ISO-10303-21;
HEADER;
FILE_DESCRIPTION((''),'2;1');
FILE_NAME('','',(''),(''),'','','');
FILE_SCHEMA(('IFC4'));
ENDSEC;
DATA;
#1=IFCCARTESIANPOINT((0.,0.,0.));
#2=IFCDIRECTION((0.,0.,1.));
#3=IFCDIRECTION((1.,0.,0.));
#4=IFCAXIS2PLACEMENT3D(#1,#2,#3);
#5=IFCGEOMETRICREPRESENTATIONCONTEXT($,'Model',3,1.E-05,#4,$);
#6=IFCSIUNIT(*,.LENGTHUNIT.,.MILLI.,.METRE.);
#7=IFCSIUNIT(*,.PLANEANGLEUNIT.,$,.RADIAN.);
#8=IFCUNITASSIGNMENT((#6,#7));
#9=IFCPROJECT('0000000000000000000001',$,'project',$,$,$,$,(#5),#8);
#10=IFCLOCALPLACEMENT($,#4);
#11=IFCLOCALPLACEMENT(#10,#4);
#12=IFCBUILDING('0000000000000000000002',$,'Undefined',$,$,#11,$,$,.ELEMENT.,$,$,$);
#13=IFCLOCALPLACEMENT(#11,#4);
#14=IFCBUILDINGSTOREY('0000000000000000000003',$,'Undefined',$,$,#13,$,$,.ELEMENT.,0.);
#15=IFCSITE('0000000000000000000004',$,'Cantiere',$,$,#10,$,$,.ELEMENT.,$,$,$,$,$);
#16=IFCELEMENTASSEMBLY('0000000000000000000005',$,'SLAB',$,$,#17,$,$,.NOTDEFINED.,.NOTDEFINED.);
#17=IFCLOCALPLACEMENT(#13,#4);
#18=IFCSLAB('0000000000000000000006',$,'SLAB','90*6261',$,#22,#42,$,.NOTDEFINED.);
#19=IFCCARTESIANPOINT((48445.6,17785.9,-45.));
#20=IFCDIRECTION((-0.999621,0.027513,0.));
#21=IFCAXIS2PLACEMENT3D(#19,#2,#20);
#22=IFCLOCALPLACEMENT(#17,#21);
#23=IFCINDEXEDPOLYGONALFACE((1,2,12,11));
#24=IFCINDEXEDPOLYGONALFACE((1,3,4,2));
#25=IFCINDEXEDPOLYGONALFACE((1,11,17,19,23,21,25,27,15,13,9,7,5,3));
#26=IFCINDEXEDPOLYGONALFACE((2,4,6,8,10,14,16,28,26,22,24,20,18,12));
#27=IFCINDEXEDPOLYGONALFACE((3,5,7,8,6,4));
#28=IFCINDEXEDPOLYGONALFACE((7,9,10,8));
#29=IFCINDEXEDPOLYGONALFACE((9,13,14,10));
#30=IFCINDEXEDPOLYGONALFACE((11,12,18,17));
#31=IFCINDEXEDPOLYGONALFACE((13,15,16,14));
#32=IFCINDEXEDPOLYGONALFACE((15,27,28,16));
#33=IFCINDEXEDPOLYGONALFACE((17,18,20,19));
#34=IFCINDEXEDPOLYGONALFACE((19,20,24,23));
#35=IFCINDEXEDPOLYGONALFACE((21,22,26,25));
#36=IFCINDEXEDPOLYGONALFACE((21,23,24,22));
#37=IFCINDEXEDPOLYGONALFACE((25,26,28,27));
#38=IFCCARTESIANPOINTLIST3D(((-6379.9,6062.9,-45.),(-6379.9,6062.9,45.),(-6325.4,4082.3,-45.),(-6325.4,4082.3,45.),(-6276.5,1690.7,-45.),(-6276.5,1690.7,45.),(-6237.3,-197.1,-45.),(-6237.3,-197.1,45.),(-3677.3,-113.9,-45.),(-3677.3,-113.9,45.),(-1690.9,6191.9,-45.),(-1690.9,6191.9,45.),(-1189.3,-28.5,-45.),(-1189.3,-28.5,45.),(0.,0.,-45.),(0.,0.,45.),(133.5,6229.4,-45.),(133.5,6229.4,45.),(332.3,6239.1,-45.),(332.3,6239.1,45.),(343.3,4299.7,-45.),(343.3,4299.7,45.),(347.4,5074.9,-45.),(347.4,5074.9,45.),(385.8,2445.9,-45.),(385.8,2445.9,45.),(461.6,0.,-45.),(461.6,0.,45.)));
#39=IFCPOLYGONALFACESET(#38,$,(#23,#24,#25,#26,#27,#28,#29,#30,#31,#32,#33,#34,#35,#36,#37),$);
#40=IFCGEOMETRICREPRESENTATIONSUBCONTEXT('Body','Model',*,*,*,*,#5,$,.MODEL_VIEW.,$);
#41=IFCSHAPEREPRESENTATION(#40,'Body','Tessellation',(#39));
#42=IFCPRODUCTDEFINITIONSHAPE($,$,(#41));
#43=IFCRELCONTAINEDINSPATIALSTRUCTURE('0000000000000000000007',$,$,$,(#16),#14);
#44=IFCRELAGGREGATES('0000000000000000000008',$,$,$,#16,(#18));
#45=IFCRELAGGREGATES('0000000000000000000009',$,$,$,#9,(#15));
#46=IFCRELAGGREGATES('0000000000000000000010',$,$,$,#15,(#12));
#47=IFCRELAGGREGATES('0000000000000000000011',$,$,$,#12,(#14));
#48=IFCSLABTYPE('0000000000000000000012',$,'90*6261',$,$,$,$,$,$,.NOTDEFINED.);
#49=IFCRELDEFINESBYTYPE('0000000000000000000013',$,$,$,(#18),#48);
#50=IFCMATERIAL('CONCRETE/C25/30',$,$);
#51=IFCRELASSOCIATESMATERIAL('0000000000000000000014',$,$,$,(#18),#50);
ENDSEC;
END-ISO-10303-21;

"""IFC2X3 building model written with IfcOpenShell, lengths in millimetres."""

from ifc_helpers import new_model, si_unit, frame, origin_with_axes, place, context, subcontext, project, spatial, polyline, outline, extrude, material, type_object, element, aggregate, save


model = new_model("IFC2X3")

# Units and contexts
model_context = context("Model", 3, precision=1e-05, world=origin_with_axes())
body_context = subcontext(model_context, "Body", "Model", "MODEL_VIEW")
ifc_project = project(units=[si_unit("LENGTHUNIT", "METRE", prefix="MILLI"), si_unit("PLANEANGLEUNIT", "RADIAN")], contexts=[model_context])

# Site, building, storey
site_placement = place(None, origin_with_axes())
site = spatial("IfcSite", under=ifc_project, at=site_placement, Name="Cantiere", CompositionType="ELEMENT")
building_placement = place(site_placement, origin_with_axes())
building = spatial("IfcBuilding", under=site, at=building_placement, Name="Undefined", CompositionType="ELEMENT")
storey_placement = place(building_placement, origin_with_axes())
storey = spatial("IfcBuildingStorey", under=building, at=storey_placement, Name="Undefined", CompositionType="ELEMENT", Elevation=0.0)

# Element assembly, slab
assembly_1_placement = place(storey_placement, origin_with_axes())
assembly_1 = element("IfcElementAssembly", 1, at=assembly_1_placement, inside=storey, Name="SLAB", AssemblyPlace="NOTDEFINED", PredefinedType="NOTDEFINED")
ifc_material_1 = material(Name="CONCRETE/C25/30")
slab_type = type_object("IfcSlabType", Name="90*6261", PredefinedType="NOTDEFINED")
slab_placement = place(assembly_1_placement, frame((48445.6, 17785.9, -45.0), z_axis=(0.0, 0.0, 1.0), x_axis=(-0.999621, 0.027513, 0.0)))
slab = element("IfcSlab", 2, at=slab_placement, type_object=slab_type, material=ifc_material_1, Name="SLAB", Description="90*6261", PredefinedType="NOTDEFINED", context=body_context, shape_type="SweptSolid", body=[
    extrude(outline(polyline([(0.0, 0.0), (461.6, 0.0), (385.8, 2445.9), (343.3, 4299.7), (347.4, 5074.9), (332.3, 6239.1), (133.5, 6229.4), (-1690.9, 6191.9), (-6379.9, 6062.9), (-6325.4, 4082.3), (-6276.5, 1690.7), (-6237.3, -197.1), (-3677.3, -113.9), (-1189.3, -28.5), (0.0, 0.0)])), frame((0.0, 0.0, -45.0), z_axis=(0.0, 0.0, 1.0), x_axis=(1.0, 0.0, 0.0)), (0.0, 0.0, 1.0), 90.0),
])
aggregate(assembly_1, [slab])

save(model, "model.ifc")
